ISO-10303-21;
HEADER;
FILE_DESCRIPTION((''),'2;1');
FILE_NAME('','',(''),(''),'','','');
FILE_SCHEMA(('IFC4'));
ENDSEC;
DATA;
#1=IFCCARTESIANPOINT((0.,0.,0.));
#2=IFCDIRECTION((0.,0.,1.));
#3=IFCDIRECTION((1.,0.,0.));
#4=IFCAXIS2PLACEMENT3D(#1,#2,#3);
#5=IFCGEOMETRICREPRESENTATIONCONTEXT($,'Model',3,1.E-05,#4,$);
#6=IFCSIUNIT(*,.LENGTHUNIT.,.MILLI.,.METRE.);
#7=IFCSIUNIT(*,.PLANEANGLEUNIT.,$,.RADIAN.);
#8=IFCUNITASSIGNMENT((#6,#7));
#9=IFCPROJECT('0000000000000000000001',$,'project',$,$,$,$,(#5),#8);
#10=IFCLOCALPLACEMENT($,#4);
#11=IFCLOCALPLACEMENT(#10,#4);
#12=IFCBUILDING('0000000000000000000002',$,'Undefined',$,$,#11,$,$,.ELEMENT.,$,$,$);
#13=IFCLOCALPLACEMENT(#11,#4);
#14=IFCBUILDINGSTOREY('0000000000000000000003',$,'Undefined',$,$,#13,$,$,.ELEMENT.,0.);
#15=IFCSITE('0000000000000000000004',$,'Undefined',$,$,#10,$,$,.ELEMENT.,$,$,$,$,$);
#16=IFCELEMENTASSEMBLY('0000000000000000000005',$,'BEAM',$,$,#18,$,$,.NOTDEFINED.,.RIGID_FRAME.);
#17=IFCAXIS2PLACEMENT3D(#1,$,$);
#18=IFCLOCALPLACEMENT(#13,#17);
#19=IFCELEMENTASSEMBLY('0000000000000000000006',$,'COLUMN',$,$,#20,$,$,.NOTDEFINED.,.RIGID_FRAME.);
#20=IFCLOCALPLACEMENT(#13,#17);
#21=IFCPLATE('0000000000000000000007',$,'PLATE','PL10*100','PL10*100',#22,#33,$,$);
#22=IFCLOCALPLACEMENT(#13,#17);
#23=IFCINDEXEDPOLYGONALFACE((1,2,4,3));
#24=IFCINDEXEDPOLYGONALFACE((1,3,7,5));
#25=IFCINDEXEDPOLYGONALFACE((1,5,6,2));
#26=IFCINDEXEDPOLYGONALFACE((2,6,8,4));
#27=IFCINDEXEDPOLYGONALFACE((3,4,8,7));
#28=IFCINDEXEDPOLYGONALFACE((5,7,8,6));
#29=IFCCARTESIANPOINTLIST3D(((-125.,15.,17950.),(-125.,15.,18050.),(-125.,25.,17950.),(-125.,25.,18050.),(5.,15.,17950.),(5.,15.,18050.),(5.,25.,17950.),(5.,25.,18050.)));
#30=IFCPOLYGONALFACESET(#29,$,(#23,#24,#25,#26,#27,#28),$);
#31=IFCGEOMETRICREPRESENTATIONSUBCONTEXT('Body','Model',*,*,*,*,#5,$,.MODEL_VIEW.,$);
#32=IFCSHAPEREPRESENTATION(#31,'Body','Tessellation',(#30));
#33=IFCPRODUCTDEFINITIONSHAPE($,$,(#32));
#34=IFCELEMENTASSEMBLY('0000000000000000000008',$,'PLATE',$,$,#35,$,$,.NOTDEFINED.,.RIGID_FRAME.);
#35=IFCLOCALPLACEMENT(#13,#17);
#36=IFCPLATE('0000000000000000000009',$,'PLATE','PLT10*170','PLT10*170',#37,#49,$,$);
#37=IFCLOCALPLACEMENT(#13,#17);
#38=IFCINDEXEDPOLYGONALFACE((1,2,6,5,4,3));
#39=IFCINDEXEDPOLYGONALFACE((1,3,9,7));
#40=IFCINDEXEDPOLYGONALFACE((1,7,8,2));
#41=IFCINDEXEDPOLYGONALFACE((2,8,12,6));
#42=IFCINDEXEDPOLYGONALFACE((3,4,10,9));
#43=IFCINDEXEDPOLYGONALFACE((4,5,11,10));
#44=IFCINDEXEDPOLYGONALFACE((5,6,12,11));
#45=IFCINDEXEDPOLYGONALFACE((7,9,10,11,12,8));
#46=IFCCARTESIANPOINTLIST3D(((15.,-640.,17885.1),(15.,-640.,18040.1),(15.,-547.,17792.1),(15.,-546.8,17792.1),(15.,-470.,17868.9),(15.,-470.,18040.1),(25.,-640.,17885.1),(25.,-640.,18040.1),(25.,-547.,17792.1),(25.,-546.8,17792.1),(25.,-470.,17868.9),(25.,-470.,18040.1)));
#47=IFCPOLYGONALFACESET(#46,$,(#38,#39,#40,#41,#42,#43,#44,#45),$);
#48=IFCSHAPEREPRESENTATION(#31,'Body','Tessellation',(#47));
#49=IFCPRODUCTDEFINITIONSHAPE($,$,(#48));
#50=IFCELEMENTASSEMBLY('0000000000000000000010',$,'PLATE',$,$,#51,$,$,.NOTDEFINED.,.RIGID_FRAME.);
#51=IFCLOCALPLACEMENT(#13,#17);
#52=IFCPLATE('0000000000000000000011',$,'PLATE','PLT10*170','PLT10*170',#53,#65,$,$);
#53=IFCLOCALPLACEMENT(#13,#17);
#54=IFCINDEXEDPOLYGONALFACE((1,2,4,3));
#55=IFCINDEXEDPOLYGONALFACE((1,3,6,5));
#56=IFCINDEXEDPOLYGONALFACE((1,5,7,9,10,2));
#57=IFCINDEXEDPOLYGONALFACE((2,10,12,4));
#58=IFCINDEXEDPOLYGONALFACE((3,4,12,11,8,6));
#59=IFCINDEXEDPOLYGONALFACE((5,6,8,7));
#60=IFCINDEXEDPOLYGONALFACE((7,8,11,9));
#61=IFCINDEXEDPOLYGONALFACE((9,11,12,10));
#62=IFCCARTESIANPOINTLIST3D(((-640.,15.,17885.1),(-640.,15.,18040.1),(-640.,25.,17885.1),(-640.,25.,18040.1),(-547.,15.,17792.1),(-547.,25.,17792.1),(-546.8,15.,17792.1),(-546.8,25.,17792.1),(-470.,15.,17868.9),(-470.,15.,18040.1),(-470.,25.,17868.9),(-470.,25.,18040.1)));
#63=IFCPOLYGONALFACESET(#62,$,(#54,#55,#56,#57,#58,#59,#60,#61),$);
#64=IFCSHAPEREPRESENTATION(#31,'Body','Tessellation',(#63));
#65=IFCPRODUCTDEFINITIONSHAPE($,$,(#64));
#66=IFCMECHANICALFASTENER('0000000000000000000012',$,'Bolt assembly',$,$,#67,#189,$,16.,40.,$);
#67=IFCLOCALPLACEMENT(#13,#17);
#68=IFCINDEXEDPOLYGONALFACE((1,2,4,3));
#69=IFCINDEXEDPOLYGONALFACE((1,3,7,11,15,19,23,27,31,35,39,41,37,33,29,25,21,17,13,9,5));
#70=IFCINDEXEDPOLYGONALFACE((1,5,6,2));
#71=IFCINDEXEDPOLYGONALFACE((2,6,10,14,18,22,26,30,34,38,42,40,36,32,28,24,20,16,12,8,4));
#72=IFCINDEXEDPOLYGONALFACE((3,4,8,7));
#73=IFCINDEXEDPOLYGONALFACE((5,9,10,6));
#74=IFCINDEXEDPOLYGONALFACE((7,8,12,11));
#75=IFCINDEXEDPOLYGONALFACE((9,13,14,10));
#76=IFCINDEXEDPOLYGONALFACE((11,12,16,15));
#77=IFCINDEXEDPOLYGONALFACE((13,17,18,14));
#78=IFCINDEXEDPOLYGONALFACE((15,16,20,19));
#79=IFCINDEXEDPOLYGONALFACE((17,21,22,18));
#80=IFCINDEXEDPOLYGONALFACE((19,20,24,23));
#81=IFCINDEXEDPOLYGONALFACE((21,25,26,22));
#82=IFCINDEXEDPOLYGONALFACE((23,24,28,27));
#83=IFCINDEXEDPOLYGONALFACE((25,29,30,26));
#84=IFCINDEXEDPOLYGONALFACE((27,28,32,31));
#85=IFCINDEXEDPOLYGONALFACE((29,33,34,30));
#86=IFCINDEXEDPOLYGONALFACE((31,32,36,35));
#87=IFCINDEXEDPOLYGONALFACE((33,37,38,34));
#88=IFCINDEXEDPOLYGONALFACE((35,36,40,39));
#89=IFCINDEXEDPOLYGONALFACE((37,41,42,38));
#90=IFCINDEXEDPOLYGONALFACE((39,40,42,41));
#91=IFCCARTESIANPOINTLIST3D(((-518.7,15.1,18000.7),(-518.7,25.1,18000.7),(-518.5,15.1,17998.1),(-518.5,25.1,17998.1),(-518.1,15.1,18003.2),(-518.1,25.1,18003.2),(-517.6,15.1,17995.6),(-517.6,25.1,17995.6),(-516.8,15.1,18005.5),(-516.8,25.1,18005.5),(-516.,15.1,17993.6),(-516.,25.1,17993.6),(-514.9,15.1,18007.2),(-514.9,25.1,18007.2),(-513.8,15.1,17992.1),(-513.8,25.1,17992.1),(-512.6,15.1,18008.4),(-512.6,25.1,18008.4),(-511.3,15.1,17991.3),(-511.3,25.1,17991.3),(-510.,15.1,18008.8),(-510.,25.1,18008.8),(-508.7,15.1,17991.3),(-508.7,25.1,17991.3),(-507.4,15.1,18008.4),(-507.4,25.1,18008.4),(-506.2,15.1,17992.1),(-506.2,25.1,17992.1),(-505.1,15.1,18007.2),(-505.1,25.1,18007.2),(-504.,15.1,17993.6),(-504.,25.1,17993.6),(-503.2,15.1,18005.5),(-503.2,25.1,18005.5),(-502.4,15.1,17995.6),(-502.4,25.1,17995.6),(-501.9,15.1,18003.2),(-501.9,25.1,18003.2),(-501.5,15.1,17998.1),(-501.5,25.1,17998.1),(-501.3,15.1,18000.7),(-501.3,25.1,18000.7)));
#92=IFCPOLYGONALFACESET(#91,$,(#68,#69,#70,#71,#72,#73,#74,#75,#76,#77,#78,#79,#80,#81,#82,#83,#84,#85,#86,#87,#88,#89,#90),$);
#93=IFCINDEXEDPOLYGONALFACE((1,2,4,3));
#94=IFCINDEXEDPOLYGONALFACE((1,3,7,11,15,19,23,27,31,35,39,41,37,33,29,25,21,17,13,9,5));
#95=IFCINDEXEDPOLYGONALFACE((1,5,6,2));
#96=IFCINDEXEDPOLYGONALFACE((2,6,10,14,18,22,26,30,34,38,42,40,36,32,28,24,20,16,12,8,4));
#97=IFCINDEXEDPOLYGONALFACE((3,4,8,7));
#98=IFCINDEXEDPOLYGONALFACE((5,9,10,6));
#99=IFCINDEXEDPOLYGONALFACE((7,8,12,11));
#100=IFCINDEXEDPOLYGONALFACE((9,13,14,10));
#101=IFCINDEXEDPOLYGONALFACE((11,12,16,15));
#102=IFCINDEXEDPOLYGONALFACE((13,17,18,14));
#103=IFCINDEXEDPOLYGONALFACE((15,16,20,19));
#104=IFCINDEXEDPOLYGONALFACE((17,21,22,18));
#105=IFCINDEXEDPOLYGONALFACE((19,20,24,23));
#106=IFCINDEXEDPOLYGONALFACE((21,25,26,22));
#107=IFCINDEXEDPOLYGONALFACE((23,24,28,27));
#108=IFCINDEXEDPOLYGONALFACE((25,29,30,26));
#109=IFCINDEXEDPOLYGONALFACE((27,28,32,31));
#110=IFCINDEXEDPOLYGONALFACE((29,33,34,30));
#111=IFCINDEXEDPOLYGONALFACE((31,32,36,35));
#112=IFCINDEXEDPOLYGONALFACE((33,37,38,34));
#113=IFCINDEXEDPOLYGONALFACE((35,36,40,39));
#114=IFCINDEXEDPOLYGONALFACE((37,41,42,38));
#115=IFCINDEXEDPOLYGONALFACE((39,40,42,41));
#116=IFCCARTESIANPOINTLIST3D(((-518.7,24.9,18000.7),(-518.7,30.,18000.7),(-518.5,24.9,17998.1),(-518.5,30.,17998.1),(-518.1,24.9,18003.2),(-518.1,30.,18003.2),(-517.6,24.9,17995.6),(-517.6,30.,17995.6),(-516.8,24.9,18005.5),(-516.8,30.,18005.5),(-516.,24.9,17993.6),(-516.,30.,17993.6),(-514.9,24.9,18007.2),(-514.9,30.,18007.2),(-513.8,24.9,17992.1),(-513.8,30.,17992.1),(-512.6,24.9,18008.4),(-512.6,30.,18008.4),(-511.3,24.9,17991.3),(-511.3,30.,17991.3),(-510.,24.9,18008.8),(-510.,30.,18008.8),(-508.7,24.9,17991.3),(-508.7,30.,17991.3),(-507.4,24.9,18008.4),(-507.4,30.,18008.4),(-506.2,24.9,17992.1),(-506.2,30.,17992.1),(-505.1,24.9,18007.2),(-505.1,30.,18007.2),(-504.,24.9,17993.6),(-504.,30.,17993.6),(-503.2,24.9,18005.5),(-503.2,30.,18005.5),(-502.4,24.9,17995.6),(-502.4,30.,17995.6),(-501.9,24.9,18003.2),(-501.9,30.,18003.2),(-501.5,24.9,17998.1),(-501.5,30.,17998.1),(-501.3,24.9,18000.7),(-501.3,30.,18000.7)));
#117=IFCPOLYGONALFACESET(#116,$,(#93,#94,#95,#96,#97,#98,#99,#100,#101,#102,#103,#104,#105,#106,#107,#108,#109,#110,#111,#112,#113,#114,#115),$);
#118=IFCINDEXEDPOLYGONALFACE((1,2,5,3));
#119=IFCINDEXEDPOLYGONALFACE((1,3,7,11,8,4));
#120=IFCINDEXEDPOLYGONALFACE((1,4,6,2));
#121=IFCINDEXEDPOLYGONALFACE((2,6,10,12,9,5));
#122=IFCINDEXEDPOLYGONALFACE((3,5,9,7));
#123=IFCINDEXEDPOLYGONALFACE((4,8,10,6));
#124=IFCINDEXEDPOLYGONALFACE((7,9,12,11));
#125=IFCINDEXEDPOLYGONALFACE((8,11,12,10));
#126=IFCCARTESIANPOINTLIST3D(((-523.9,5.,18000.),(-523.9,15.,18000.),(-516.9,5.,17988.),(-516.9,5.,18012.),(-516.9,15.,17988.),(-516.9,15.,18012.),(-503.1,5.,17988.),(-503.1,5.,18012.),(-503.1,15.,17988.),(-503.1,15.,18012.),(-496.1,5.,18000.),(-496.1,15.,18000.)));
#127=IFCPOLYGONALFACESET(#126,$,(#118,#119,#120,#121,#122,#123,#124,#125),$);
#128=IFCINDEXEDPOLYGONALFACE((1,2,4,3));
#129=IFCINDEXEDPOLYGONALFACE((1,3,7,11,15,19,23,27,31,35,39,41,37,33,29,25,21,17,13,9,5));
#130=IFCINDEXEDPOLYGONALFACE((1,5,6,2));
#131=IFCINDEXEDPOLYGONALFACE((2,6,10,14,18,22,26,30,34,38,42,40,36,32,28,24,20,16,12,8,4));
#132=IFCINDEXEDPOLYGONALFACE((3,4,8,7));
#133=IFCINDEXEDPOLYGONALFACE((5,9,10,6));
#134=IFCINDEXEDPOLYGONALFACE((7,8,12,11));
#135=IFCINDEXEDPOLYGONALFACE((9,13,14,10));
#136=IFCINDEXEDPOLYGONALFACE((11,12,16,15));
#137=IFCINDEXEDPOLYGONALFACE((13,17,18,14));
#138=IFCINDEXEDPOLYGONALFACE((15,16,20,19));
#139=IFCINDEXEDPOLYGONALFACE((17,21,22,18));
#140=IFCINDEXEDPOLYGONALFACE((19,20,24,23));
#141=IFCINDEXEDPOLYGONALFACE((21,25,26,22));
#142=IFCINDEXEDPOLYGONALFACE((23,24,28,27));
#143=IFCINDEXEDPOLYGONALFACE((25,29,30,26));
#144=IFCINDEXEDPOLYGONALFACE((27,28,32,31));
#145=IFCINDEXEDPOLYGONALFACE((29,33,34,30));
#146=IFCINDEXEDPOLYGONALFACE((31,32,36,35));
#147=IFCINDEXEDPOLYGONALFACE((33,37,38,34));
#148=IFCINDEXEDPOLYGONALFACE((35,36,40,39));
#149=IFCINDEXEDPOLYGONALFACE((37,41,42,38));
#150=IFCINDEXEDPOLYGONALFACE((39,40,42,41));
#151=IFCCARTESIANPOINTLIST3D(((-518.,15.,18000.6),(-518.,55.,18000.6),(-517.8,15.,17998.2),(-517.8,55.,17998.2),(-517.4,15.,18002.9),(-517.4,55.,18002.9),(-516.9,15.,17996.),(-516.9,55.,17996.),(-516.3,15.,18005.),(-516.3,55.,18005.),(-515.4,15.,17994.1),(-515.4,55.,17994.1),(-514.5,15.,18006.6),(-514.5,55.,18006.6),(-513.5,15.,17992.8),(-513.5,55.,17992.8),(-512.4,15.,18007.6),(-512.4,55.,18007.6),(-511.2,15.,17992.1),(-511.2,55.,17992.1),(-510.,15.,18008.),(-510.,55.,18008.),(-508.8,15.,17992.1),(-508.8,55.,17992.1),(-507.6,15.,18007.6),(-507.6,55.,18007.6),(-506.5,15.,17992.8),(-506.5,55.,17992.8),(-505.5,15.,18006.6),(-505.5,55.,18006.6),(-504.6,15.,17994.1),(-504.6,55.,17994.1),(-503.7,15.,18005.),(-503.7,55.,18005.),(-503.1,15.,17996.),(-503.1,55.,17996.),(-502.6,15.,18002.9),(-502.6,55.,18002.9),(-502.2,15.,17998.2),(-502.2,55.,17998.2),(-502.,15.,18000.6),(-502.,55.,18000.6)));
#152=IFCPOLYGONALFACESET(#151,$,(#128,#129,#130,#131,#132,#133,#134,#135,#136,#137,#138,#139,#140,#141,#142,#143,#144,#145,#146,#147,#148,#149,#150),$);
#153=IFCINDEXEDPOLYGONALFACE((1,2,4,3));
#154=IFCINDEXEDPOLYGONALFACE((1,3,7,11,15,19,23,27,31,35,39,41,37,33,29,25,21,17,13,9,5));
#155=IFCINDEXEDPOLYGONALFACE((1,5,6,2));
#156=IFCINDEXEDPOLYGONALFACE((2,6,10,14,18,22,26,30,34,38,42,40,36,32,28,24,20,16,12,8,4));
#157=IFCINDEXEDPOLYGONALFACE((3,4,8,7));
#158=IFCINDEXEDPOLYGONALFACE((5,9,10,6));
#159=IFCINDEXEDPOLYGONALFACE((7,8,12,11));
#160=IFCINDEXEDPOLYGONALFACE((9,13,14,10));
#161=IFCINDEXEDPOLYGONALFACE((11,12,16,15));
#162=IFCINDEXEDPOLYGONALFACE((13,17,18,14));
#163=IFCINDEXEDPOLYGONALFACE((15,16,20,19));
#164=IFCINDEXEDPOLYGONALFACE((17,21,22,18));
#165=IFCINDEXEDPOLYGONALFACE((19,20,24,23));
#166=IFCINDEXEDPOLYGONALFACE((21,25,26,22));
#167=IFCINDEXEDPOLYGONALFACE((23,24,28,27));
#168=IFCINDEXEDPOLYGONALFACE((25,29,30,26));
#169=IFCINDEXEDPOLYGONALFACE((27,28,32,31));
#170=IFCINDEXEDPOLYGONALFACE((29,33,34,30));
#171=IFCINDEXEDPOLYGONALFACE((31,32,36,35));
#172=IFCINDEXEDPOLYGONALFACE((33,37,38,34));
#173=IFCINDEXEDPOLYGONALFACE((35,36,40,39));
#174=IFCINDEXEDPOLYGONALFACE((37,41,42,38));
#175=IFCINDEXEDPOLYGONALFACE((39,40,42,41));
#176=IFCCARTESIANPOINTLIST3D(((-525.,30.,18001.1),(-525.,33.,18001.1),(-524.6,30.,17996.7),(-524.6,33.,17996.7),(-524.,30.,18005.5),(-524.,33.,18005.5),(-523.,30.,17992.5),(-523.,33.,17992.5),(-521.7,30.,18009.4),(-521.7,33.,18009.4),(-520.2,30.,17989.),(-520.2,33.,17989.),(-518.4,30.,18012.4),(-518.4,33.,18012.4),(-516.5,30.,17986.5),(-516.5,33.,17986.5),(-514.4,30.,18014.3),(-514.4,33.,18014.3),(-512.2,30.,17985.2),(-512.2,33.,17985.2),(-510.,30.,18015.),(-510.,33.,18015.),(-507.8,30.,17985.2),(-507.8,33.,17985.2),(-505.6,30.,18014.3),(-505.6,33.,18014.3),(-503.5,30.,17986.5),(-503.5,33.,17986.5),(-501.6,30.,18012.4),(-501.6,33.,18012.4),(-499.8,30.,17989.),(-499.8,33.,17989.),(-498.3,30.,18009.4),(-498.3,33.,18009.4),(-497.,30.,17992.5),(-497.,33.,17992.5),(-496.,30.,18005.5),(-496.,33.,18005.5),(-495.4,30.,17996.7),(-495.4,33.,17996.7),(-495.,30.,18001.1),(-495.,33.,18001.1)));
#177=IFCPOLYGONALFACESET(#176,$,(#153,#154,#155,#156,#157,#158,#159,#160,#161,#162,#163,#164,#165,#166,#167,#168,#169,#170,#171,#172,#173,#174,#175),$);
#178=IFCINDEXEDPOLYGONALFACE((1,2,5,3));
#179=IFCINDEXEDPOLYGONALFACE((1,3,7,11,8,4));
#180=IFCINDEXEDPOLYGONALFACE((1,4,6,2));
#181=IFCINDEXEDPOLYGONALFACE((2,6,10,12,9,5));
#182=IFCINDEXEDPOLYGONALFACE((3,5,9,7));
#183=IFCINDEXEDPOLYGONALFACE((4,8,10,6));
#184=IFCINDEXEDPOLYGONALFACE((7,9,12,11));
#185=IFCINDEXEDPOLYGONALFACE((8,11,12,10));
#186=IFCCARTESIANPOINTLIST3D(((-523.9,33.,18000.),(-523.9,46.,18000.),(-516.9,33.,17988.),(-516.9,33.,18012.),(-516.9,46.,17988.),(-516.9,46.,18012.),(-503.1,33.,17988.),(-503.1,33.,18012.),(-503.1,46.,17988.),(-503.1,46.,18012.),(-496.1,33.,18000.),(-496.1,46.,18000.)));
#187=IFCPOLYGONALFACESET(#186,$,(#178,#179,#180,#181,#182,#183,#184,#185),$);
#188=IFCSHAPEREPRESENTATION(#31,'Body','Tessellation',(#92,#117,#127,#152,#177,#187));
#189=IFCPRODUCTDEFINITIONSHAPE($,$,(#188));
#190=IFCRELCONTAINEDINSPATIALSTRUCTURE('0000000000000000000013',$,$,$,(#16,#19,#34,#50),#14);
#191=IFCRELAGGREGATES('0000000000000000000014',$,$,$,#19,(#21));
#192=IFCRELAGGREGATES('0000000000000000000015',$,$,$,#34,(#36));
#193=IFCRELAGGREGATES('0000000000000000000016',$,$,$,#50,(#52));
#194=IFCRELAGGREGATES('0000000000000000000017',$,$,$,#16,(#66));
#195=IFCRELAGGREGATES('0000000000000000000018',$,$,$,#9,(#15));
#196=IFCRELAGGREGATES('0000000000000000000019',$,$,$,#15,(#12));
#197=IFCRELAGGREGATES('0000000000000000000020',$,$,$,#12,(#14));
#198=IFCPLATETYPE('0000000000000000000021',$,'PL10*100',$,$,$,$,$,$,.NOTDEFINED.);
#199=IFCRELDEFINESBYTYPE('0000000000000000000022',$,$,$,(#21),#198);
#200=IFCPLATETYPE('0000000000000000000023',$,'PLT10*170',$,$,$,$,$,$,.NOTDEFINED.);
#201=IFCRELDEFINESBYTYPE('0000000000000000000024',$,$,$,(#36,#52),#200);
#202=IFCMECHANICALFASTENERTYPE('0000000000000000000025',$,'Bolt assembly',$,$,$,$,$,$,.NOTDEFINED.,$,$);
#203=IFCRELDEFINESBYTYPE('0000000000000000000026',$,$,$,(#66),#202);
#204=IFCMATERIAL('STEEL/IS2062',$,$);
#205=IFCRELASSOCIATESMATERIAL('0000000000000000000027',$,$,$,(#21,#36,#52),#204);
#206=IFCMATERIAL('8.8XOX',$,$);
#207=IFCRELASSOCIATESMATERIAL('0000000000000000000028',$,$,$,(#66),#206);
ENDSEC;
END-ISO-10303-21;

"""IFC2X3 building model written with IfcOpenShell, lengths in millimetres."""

from ifc_helpers import new_model, si_unit, frame, origin_with_axes, origin_2d_with_axis, place, context, subcontext, project, spatial, polyline, circle, outline, extrude, source, transform, mapped, material, type_object, element, aggregate, save


model = new_model("IFC2X3")

# Units and contexts
model_context = context("Model", 3, precision=1e-05, world=origin_with_axes())
body_context = subcontext(model_context, "Body", "Model", "MODEL_VIEW")
ifc_project = project(units=[si_unit("LENGTHUNIT", "METRE", prefix="MILLI"), si_unit("PLANEANGLEUNIT", "RADIAN")], contexts=[model_context])

# Site, building, storey
site_placement = place(None, origin_with_axes())
site = spatial("IfcSite", under=ifc_project, at=site_placement, Name="Undefined", CompositionType="ELEMENT")
building_placement = place(site_placement, origin_with_axes())
building = spatial("IfcBuilding", under=site, at=building_placement, Name="Undefined", CompositionType="ELEMENT")
storey_placement = place(building_placement, origin_with_axes())
storey = spatial("IfcBuildingStorey", under=building, at=storey_placement, Name="Undefined", CompositionType="ELEMENT", Elevation=0.0)

# Shared definitions
ifc_material_1 = material(Name="STEEL/IS2062")

# Element assembly
assembly_1_placement = place(storey_placement, origin_with_axes())
assembly_1 = element("IfcElementAssembly", 1, at=assembly_1_placement, inside=storey, Name="BEAM", AssemblyPlace="NOTDEFINED", PredefinedType="RIGID_FRAME")

# Element assembly, plate
assembly_2_placement = place(storey_placement, origin_with_axes())
assembly_2 = element("IfcElementAssembly", 2, at=assembly_2_placement, inside=storey, Name="COLUMN", AssemblyPlace="NOTDEFINED", PredefinedType="RIGID_FRAME")
plate_type_1 = type_object("IfcPlateType", Name="PL10*100", PredefinedType="NOTDEFINED")
plate_1_placement = place(assembly_2_placement, frame((5.0, 20.0, 18050.0), z_axis=(0.0, 1.0, 0.0), x_axis=(0.0, 0.0, -1.0)))
plate_1 = element("IfcPlate", 3, at=plate_1_placement, type_object=plate_type_1, material=ifc_material_1, Name="PLATE", Description="PL10*100", ObjectType="PL10*100", context=body_context, shape_type="SweptSolid", body=[
    extrude(outline(polyline([(0.0, 0.0), (100.0, 0.0), (100.0, 130.0), (0.0, 130.0), (0.0, 0.0)])), frame((0.0, 0.0, -5.0), z_axis=(0.0, 0.0, 1.0), x_axis=(1.0, 0.0, 0.0)), (0.0, 0.0, 1.0), 10.0),
])
aggregate(assembly_2, [plate_1])

# Element assemblies, plates
assembly_3_placement = place(storey_placement, origin_with_axes())
assembly_3 = element("IfcElementAssembly", 4, at=assembly_3_placement, inside=storey, Name="PLATE", AssemblyPlace="NOTDEFINED", PredefinedType="RIGID_FRAME")
plate_type_2 = type_object("IfcPlateType", Name="PLT10*170", PredefinedType="NOTDEFINED")
plate_2_placement = place(assembly_3_placement, frame((20.0, -640.0, 18040.1), z_axis=(1.0, 0.0, 0.0), x_axis=(0.0, 0.0, -1.0)))
plate_2 = element("IfcPlate", 5, at=plate_2_placement, type_object=plate_type_2, material=ifc_material_1, Name="PLATE", Description="PLT10*170", ObjectType="PLT10*170", context=body_context, shape_type="SweptSolid", body=[
    extrude(outline(polyline([(0.0, 0.0), (155.0, 0.0), (248.0, 93.0), (248.0, 93.2), (171.2, 170.0), (0.0, 170.0), (0.0, 0.0)])), frame((0.0, 0.0, -5.0), z_axis=(0.0, 0.0, 1.0), x_axis=(1.0, 0.0, 0.0)), (0.0, 0.0, 1.0), 10.0),
])
aggregate(assembly_3, [plate_2])
assembly_4_placement = place(storey_placement, origin_with_axes())
assembly_4 = element("IfcElementAssembly", 6, at=assembly_4_placement, inside=storey, Name="PLATE", AssemblyPlace="NOTDEFINED", PredefinedType="RIGID_FRAME")
plate_3_placement = place(assembly_4_placement, frame((-640.0, 20.0, 18040.1), z_axis=(0.0, -1.0, 0.0), x_axis=(0.0, 0.0, -1.0)))
plate_3 = element("IfcPlate", 7, at=plate_3_placement, type_object=plate_type_2, material=ifc_material_1, Name="PLATE", Description="PLT10*170", ObjectType="PLT10*170", context=body_context, shape_type="SweptSolid", body=[
    extrude(outline(polyline([(0.0, 0.0), (155.0, 0.0), (248.0, 93.0), (248.0, 93.2), (171.2, 170.0), (0.0, 170.0), (0.0, 0.0)])), frame((0.0, 0.0, -5.0), z_axis=(0.0, 0.0, 1.0), x_axis=(1.0, 0.0, 0.0)), (0.0, 0.0, 1.0), 10.0),
])
aggregate(assembly_4, [plate_3])

# Mechanical fastener
ifc_material_2 = material(Name="8.8XOX")
mechanical_fastener_type = type_object("IfcMechanicalFastenerType", Name="Bolt assembly")
shared_shape_1 = source(origin_with_axes(), body_context, "Body", "SweptSolid", [
    extrude(circle(Radius=8.8, at=origin_2d_with_axis()), frame((0.0, 15.1, 0.0), z_axis=(0.0, 1.0, 0.0), x_axis=(1.0, 0.0, 0.0)), (0.0, 0.0, 1.0), 10.0),
    extrude(circle(Radius=8.8, at=origin_2d_with_axis()), frame((0.0, 24.9, 0.0), z_axis=(0.0, 1.0, 0.0), x_axis=(1.0, 0.0, 0.0)), (0.0, 0.0, 1.0), 5.1),
    extrude(outline(polyline([(12.0, -6.9), (12.0, 6.9), (0.0, 13.9), (-12.0, 6.9), (-12.0, -6.9), (0.0, -13.9), (12.0, -6.9)])), frame((0.0, 5.0, 0.0), z_axis=(0.0, 1.0, 0.0), x_axis=(1.0, 0.0, 0.0)), (0.0, 0.0, 1.0), 10.0),
    extrude(circle(Radius=8.0, at=origin_2d_with_axis()), frame((0.0, 15.0, 0.0), z_axis=(0.0, 1.0, 0.0), x_axis=(1.0, 0.0, 0.0)), (0.0, 0.0, 1.0), 40.0),
    extrude(circle(Radius=15.0, at=origin_2d_with_axis()), frame((0.0, 30.0, 0.0), z_axis=(0.0, 1.0, 0.0), x_axis=(1.0, 0.0, 0.0)), (0.0, 0.0, 1.0), 3.0),
    extrude(outline(polyline([(12.0, -6.9), (12.0, 6.9), (0.0, 13.9), (-12.0, 6.9), (-12.0, -6.9), (0.0, -13.9), (12.0, -6.9)])), frame((0.0, 33.0, 0.0), z_axis=(0.0, 1.0, 0.0), x_axis=(1.0, 0.0, 0.0)), (0.0, 0.0, 1.0), 13.0),
])
mechanical_fastener_1_placement = place(assembly_1_placement, frame((-510.0, 0.0, 18000.0), z_axis=(-1.0, 0.0, 0.0), x_axis=(0.0, 0.0, 1.0)))
mechanical_fastener_1 = element("IfcMechanicalFastener", 8, at=mechanical_fastener_1_placement, type_object=mechanical_fastener_type, material=ifc_material_2, Name="Bolt assembly", NominalDiameter=16.0, NominalLength=40.0, context=body_context, shape_type="MappedRepresentation", body=[
    mapped(shared_shape_1, transform((0.0, 0.0, 0.0))),
])
aggregate(assembly_1, [mechanical_fastener_1])

save(model, "model.ifc")
